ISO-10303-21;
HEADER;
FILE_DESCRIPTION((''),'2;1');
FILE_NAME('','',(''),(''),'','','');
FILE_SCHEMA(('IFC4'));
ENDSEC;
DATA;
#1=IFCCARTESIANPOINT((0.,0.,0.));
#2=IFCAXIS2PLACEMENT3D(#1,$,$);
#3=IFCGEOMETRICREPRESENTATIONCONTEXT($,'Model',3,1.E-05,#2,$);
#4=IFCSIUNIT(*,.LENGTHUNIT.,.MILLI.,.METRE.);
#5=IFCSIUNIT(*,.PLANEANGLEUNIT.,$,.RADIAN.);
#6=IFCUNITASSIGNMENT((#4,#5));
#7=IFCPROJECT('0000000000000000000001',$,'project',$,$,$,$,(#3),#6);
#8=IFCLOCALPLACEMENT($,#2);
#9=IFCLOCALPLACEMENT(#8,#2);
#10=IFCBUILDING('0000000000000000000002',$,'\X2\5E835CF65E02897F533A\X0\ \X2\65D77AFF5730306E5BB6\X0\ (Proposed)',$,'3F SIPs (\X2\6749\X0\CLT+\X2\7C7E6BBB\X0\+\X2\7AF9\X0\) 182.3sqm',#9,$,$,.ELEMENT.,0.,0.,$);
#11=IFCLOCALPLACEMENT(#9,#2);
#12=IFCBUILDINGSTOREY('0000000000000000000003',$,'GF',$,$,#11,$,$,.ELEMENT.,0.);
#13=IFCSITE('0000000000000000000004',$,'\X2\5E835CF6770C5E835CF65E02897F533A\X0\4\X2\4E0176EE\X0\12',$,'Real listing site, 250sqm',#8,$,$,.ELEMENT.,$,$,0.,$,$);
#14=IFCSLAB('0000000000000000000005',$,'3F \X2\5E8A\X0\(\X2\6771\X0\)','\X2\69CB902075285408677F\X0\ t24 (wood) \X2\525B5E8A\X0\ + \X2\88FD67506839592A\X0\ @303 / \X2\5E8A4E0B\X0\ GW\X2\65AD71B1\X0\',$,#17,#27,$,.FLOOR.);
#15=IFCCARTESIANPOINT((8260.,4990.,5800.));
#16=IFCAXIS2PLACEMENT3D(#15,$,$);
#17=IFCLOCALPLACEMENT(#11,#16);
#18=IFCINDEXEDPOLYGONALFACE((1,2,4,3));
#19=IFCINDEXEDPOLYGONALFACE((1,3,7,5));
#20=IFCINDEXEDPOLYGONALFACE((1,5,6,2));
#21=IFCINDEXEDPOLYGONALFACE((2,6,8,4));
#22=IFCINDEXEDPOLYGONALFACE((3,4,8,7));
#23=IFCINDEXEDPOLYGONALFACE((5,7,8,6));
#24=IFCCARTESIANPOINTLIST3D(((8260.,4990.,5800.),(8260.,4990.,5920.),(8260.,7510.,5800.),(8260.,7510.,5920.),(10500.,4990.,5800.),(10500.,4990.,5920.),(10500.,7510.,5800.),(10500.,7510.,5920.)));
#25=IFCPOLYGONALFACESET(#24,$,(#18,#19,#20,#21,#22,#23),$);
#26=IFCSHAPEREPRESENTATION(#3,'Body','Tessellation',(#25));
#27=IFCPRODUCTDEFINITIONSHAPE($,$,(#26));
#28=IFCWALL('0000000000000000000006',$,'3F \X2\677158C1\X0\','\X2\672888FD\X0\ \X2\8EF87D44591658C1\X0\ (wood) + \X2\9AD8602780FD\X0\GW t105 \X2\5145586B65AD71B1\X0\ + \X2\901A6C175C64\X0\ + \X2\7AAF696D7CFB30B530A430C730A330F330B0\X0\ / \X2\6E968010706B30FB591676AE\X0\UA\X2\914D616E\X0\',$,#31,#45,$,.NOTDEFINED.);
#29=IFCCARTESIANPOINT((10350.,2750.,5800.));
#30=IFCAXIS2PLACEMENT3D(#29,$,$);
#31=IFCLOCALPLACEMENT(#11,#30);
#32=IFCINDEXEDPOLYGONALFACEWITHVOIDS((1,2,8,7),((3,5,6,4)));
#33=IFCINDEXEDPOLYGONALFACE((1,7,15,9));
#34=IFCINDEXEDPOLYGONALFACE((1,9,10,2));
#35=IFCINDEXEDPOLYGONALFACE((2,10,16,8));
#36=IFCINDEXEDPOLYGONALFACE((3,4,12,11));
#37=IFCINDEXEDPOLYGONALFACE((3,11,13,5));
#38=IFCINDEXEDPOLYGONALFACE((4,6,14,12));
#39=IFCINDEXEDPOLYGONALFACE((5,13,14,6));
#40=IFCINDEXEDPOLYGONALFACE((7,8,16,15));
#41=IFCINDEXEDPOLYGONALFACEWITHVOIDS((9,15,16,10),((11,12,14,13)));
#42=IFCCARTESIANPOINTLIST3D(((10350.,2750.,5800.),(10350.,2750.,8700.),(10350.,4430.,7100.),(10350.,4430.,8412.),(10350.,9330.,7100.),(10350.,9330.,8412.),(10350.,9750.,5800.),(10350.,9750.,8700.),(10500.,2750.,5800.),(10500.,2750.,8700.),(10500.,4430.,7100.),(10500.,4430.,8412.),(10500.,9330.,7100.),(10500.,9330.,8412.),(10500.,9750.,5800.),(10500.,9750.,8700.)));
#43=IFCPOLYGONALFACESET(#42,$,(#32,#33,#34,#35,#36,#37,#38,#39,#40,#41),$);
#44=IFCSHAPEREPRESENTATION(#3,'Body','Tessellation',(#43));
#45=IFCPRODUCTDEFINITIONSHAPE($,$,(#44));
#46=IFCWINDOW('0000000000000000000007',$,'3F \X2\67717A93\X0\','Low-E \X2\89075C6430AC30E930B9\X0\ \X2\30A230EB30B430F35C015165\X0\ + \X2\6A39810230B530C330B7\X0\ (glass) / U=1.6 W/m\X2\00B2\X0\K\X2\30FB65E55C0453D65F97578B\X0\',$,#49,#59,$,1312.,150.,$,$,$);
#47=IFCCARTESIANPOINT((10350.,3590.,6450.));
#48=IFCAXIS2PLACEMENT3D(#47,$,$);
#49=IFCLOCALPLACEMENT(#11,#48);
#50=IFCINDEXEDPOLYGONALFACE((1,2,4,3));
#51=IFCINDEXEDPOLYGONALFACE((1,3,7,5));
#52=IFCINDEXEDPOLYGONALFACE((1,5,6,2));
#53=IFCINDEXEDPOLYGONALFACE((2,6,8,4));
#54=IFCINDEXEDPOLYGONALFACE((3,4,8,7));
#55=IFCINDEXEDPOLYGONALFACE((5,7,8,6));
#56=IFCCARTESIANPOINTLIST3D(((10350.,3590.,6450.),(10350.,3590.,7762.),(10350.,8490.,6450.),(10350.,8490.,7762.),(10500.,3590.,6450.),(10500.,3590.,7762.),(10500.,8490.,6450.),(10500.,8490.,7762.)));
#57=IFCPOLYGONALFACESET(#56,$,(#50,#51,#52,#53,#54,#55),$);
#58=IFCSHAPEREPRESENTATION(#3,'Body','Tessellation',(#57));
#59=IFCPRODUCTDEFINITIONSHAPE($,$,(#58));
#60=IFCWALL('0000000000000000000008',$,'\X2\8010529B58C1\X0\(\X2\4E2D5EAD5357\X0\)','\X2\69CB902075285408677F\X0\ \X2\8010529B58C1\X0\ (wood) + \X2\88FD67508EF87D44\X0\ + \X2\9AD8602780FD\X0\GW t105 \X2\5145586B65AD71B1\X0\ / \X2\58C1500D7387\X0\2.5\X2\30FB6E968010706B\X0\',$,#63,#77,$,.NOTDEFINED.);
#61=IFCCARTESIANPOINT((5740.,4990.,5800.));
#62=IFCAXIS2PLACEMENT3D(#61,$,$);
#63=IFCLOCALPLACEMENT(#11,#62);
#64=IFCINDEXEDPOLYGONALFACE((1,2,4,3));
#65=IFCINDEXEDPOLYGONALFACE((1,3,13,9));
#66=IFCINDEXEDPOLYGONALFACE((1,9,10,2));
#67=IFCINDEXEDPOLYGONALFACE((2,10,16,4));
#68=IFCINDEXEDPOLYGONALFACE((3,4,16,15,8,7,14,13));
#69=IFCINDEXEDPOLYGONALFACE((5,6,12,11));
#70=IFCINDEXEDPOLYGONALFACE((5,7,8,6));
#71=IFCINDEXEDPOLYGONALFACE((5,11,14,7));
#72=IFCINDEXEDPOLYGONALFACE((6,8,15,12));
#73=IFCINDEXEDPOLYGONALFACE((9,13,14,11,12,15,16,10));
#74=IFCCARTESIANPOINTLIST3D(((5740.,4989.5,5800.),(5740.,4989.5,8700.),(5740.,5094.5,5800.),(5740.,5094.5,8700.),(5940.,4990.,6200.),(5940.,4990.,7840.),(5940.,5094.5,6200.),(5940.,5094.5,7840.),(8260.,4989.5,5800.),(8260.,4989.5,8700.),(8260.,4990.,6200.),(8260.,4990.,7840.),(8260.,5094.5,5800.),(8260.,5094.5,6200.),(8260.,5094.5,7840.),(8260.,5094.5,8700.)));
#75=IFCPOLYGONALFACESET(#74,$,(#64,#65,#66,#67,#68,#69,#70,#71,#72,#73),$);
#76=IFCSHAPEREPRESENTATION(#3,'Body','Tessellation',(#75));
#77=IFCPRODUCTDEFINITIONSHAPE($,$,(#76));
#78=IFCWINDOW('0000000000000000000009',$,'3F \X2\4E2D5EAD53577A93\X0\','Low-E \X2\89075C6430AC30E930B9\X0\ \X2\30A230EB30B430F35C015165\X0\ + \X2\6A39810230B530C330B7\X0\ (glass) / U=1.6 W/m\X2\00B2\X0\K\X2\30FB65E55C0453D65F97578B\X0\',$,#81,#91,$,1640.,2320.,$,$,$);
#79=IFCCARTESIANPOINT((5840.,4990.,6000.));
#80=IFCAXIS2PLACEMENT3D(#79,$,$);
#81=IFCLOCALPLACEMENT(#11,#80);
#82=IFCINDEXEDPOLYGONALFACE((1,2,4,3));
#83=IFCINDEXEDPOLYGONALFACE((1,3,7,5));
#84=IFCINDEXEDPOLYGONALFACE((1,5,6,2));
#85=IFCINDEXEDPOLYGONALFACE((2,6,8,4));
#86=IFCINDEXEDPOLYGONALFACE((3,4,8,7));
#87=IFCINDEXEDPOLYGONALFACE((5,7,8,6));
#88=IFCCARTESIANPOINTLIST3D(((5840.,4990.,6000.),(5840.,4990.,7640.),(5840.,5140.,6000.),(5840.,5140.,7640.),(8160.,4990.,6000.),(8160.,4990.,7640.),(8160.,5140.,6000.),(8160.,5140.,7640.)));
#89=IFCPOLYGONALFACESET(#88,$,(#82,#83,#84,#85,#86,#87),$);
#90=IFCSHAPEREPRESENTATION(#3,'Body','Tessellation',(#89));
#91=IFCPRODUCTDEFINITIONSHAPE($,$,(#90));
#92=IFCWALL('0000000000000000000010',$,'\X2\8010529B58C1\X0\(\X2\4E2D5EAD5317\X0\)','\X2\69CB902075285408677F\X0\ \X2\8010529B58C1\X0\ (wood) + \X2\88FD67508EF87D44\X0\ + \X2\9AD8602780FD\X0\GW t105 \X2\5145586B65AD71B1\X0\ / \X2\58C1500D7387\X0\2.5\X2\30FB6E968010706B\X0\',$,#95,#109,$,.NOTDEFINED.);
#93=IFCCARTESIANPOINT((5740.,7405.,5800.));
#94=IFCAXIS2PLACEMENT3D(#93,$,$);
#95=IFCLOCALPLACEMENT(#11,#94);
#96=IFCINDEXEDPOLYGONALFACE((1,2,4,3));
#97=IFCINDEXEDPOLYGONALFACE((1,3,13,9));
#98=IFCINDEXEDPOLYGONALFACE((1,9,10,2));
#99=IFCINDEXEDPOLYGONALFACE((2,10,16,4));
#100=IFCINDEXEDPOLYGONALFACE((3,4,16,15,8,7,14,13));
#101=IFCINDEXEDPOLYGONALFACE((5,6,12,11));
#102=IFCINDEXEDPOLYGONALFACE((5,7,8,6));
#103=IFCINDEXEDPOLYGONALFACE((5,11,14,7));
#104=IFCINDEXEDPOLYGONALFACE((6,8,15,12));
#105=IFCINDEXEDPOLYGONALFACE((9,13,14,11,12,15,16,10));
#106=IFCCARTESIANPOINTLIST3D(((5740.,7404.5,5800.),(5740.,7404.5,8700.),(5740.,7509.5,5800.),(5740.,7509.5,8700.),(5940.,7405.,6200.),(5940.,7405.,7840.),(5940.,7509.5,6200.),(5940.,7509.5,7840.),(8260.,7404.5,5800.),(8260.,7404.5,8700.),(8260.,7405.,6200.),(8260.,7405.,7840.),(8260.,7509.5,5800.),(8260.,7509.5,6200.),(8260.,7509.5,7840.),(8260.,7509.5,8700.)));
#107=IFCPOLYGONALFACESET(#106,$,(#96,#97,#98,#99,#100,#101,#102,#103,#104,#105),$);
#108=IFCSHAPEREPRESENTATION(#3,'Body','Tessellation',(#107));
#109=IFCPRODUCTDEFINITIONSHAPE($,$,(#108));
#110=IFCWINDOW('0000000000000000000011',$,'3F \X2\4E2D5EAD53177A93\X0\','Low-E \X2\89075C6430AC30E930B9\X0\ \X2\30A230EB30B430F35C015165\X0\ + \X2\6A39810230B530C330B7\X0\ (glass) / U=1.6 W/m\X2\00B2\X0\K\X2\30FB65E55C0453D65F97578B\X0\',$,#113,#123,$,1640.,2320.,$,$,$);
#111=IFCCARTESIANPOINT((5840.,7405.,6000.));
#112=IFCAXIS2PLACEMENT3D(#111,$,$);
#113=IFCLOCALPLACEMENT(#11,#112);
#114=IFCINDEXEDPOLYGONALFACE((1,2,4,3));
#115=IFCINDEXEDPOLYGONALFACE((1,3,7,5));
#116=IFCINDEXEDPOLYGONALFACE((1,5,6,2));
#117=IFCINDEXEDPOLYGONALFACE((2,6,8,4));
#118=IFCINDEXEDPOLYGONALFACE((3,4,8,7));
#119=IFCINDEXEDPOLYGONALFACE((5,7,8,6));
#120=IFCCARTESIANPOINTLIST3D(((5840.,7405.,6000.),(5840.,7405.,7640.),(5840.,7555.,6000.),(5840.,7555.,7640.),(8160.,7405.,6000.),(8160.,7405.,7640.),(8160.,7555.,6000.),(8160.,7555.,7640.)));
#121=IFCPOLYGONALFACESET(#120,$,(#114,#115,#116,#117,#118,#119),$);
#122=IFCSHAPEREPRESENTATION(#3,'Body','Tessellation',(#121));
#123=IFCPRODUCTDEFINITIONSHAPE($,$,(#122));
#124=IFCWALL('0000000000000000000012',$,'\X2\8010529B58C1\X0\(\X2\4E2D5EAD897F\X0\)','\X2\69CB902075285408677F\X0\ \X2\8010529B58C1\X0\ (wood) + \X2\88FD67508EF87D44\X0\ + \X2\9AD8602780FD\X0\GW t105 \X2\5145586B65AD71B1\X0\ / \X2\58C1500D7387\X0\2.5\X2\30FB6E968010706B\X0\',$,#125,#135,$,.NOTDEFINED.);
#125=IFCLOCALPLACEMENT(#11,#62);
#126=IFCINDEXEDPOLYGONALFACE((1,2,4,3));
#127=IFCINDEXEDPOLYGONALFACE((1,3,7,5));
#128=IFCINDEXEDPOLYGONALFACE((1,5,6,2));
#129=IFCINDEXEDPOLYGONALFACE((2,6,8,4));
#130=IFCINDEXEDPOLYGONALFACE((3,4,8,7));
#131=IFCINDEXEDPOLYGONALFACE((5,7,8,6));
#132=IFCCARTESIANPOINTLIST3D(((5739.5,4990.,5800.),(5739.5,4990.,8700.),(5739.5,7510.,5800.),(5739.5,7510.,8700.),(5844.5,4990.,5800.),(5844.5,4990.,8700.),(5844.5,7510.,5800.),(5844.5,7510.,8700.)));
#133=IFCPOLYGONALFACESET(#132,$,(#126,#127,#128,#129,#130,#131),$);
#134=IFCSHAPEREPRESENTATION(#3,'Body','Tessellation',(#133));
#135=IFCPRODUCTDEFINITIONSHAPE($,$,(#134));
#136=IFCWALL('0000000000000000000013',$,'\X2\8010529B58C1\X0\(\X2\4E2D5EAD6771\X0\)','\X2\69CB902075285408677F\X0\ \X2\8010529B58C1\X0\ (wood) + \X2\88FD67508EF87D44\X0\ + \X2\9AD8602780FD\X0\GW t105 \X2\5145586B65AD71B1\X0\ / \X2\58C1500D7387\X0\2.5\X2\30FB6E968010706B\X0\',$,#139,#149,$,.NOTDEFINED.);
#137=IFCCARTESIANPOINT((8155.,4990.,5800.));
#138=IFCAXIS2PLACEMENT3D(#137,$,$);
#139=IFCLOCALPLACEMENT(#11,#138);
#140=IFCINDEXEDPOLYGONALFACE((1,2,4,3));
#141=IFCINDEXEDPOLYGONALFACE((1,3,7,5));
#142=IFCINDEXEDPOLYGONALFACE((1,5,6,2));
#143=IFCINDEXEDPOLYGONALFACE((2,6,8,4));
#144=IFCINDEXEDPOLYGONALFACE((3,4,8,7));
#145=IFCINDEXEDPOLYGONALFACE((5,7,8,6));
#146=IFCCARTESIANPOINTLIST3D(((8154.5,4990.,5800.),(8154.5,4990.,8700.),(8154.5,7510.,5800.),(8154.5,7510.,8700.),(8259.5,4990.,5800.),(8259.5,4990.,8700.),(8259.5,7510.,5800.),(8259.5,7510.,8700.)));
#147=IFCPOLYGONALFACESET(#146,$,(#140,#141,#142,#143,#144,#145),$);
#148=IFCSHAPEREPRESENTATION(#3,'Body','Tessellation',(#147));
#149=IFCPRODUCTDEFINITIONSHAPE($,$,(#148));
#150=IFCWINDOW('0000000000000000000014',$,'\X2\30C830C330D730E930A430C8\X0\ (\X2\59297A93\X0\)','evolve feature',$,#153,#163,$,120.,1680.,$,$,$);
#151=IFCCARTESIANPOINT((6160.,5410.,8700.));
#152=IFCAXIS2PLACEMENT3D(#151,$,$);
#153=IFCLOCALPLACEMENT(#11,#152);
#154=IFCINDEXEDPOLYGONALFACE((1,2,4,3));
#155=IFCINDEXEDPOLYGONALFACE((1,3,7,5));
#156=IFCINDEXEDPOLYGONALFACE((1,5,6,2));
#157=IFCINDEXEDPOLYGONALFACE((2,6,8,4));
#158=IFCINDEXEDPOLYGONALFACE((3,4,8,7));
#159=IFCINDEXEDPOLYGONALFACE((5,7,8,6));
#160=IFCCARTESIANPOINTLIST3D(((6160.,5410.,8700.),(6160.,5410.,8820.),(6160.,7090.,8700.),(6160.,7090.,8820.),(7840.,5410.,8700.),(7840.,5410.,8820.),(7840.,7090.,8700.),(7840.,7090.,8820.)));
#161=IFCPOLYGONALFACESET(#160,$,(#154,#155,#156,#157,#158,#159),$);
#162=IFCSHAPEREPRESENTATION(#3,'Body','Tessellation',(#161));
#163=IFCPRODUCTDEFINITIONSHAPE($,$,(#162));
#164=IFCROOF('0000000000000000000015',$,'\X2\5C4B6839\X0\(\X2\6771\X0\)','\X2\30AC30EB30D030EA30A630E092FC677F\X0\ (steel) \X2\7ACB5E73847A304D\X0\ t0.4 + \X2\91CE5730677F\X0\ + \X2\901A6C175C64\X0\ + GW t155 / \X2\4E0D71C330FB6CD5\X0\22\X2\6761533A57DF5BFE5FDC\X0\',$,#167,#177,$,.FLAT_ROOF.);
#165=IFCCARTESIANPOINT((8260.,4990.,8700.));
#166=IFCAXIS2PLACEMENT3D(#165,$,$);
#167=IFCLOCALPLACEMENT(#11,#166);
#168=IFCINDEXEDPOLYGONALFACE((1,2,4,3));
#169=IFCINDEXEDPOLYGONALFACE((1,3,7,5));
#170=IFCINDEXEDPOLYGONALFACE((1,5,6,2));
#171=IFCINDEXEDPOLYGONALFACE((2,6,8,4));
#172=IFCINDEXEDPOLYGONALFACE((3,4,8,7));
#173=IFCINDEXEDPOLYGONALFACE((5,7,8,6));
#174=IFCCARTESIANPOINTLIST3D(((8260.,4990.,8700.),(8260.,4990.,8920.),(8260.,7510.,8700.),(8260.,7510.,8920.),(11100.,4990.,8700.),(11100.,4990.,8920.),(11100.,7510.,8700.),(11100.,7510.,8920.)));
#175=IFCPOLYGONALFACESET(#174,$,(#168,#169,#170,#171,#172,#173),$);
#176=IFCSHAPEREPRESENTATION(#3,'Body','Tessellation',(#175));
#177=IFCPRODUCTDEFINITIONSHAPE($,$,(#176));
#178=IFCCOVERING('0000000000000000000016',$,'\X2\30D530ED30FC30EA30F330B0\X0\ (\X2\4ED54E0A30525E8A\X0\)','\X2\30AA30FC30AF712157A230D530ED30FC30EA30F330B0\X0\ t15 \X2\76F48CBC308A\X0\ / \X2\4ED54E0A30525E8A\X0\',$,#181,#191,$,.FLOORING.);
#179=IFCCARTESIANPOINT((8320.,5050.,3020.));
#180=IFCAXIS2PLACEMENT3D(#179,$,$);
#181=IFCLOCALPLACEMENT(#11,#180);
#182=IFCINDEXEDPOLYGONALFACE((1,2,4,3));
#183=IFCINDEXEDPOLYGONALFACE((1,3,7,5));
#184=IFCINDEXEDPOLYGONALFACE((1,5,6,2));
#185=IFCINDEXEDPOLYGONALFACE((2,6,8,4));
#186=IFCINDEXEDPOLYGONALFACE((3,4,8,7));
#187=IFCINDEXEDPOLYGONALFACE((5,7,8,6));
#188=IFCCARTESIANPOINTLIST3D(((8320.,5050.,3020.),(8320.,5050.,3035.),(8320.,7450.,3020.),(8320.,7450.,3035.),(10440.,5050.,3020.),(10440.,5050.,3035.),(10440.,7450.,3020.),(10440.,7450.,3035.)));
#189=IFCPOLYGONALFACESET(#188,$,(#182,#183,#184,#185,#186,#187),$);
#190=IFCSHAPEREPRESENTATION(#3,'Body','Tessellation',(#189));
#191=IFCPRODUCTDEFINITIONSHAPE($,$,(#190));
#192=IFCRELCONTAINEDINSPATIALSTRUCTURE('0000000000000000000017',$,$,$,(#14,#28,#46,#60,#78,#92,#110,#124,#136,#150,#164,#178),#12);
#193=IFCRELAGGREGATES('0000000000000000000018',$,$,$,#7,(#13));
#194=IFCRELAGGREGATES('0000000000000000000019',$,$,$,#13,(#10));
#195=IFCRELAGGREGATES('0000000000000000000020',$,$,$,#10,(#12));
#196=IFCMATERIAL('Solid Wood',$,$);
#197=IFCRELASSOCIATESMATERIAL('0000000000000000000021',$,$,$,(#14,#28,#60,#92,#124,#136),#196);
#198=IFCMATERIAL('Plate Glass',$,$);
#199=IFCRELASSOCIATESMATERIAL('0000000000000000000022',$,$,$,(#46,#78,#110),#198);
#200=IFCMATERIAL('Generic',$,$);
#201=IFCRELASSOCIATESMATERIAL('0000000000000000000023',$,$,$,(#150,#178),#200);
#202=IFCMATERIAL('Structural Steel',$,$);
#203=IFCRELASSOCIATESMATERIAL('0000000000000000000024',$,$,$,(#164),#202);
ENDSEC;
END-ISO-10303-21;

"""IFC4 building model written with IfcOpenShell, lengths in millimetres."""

from ifc_helpers import new_model, si_unit, frame, frame_2d, origin, place, context, project, spatial, rectangle, extrude, material, element, fill, save


model = new_model("IFC4")

# Units and contexts
model_context = context("Model", 3, precision=1e-05, world=origin())
ifc_project = project(units=[si_unit("LENGTHUNIT", "METRE", prefix="MILLI"), si_unit("PLANEANGLEUNIT", "RADIAN")], contexts=[model_context])

# Site, building, storey
site_placement = place(None, origin())
site = spatial("IfcSite", under=ifc_project, at=site_placement, Name="広島県広島市西区4丁目12", ObjectType="Real listing site, 250sqm", CompositionType="ELEMENT", RefElevation=0.0)
building_placement = place(site_placement, origin())
building = spatial("IfcBuilding", under=site, at=building_placement, Name="広島市西区 旗竿地の家 (Proposed)", ObjectType="3F SIPs (杉CLT+籾殻+竹) 182.3sqm", CompositionType="ELEMENT", ElevationOfRefHeight=0.0, ElevationOfTerrain=0.0)
storey_placement = place(building_placement, origin())
storey = spatial("IfcBuildingStorey", under=building, at=storey_placement, Name="GF", CompositionType="ELEMENT", Elevation=0.0)

# Slab
ifc_material_1 = material(Name="Solid Wood")
slab_placement = place(storey_placement, frame((8260.0, 4990.0, 5800.0)))
element("IfcSlab", 1, at=slab_placement, inside=storey, material=ifc_material_1, Name="3F 床(東)", Description="構造用合板 t24 (wood) 剛床 + 製材根太 @303 / 床下 GW断熱", PredefinedType="FLOOR", context=model_context, shape_type="SweptSolid", body=[
    extrude(rectangle(XDim=2240.0, YDim=2520.0, at=frame_2d((1120.0, 1260.0))), frame((8260.0, 4990.0, 5800.0)), (0.0, 0.0, 1.0), 120.0),
])

# Walls, openings, windows
wall_1_placement = place(storey_placement, frame((10350.0, 2750.0, 5800.0)))
wall_1 = element("IfcWall", 2, at=wall_1_placement, inside=storey, material=ifc_material_1, Name="3F 東壁", Description="木製 軸組外壁 (wood) + 高性能GW t105 充填断熱 + 通気層 + 窯業系サイディング / 準耐火・外皮UA配慮", PredefinedType="NOTDEFINED", context=model_context, shape_type="SweptSolid", body=[
    extrude(rectangle(XDim=150.0, YDim=7000.0, at=frame_2d((75.0, 3500.0))), frame((10350.0, 2750.0, 5800.0)), (0.0, 0.0, 1.0), 2900.0),
])
opening_1_placement = place(storey_placement, frame((10350.0, 3590.0, 6450.0)))
opening_1 = element("IfcOpeningElement", 3, at=opening_1_placement, cuts=wall_1, PredefinedType="NOTDEFINED", context=model_context, shape_type="SweptSolid", body=[
    extrude(rectangle(XDim=150.0, YDim=4900.0, at=frame_2d((75.0, 2450.0))), frame((10350.0, 3590.0, 6450.0)), (0.0, 0.0, 1.0), 1312.0),
])
ifc_material_2 = material(Name="Plate Glass")
window_1_placement = place(storey_placement, frame((10350.0, 3590.0, 6450.0)))
window_1 = element("IfcWindow", 4, at=window_1_placement, inside=storey, material=ifc_material_2, Name="3F 東窓", Description="Low-E 複層ガラス アルゴン封入 + 樹脂サッシ (glass) / U=1.6 W/m²K・日射取得型", OverallHeight=1312.0, OverallWidth=150.0, context=model_context, shape_type="SweptSolid", body=[
    extrude(rectangle(XDim=150.0, YDim=4900.0, at=frame_2d((75.0, 2450.0))), frame((10350.0, 3590.0, 6450.0)), (0.0, 0.0, 1.0), 1312.0),
])
fill(opening_1, window_1)
wall_2_placement = place(storey_placement, frame((5740.0, 4990.0, 5800.0)))
wall_2 = element("IfcWall", 5, at=wall_2_placement, inside=storey, material=ifc_material_1, Name="耐力壁(中庭南)", Description="構造用合板 耐力壁 (wood) + 製材軸組 + 高性能GW t105 充填断熱 / 壁倍率2.5・準耐火", PredefinedType="NOTDEFINED", context=model_context, shape_type="SweptSolid", body=[
    extrude(rectangle(XDim=2520.0, YDim=105.0, at=frame_2d((1260.0, 52.0))), frame((5740.0, 4990.0, 5800.0)), (0.0, 0.0, 1.0), 2900.0),
])
opening_2_placement = place(storey_placement, frame((5840.0, 4990.0, 6000.0)))
opening_2 = element("IfcOpeningElement", 6, at=opening_2_placement, cuts=wall_2, PredefinedType="NOTDEFINED", context=model_context, shape_type="SweptSolid", body=[
    extrude(rectangle(XDim=2320.0, YDim=150.0, at=frame_2d((1160.0, 75.0))), frame((5840.0, 4990.0, 6000.0)), (0.0, 0.0, 1.0), 1640.0),
])
window_2_placement = place(storey_placement, frame((5840.0, 4990.0, 6000.0)))
window_2 = element("IfcWindow", 7, at=window_2_placement, inside=storey, material=ifc_material_2, Name="3F 中庭南窓", Description="Low-E 複層ガラス アルゴン封入 + 樹脂サッシ (glass) / U=1.6 W/m²K・日射取得型", OverallHeight=1640.0, OverallWidth=2320.0, context=model_context, shape_type="SweptSolid", body=[
    extrude(rectangle(XDim=2320.0, YDim=150.0, at=frame_2d((1160.0, 75.0))), frame((5840.0, 4990.0, 6000.0)), (0.0, 0.0, 1.0), 1640.0),
])
fill(opening_2, window_2)
wall_3_placement = place(storey_placement, frame((5740.0, 7405.0, 5800.0)))
wall_3 = element("IfcWall", 8, at=wall_3_placement, inside=storey, material=ifc_material_1, Name="耐力壁(中庭北)", Description="構造用合板 耐力壁 (wood) + 製材軸組 + 高性能GW t105 充填断熱 / 壁倍率2.5・準耐火", PredefinedType="NOTDEFINED", context=model_context, shape_type="SweptSolid", body=[
    extrude(rectangle(XDim=2520.0, YDim=105.0, at=frame_2d((1260.0, 52.0))), frame((5740.0, 7405.0, 5800.0)), (0.0, 0.0, 1.0), 2900.0),
])
opening_3_placement = place(storey_placement, frame((5840.0, 7405.0, 6000.0)))
opening_3 = element("IfcOpeningElement", 9, at=opening_3_placement, cuts=wall_3, PredefinedType="NOTDEFINED", context=model_context, shape_type="SweptSolid", body=[
    extrude(rectangle(XDim=2320.0, YDim=150.0, at=frame_2d((1160.0, 75.0))), frame((5840.0, 7405.0, 6000.0)), (0.0, 0.0, 1.0), 1640.0),
])
window_3_placement = place(storey_placement, frame((5840.0, 7405.0, 6000.0)))
window_3 = element("IfcWindow", 10, at=window_3_placement, inside=storey, material=ifc_material_2, Name="3F 中庭北窓", Description="Low-E 複層ガラス アルゴン封入 + 樹脂サッシ (glass) / U=1.6 W/m²K・日射取得型", OverallHeight=1640.0, OverallWidth=2320.0, context=model_context, shape_type="SweptSolid", body=[
    extrude(rectangle(XDim=2320.0, YDim=150.0, at=frame_2d((1160.0, 75.0))), frame((5840.0, 7405.0, 6000.0)), (0.0, 0.0, 1.0), 1640.0),
])
fill(opening_3, window_3)

# Walls
wall_4_placement = place(storey_placement, frame((5740.0, 4990.0, 5800.0)))
element("IfcWall", 11, at=wall_4_placement, inside=storey, material=ifc_material_1, Name="耐力壁(中庭西)", Description="構造用合板 耐力壁 (wood) + 製材軸組 + 高性能GW t105 充填断熱 / 壁倍率2.5・準耐火", PredefinedType="NOTDEFINED", context=model_context, shape_type="SweptSolid", body=[
    extrude(rectangle(XDim=105.0, YDim=2520.0, at=frame_2d((52.0, 1260.0))), frame((5740.0, 4990.0, 5800.0)), (0.0, 0.0, 1.0), 2900.0),
])
wall_5_placement = place(storey_placement, frame((8155.0, 4990.0, 5800.0)))
element("IfcWall", 12, at=wall_5_placement, inside=storey, material=ifc_material_1, Name="耐力壁(中庭東)", Description="構造用合板 耐力壁 (wood) + 製材軸組 + 高性能GW t105 充填断熱 / 壁倍率2.5・準耐火", PredefinedType="NOTDEFINED", context=model_context, shape_type="SweptSolid", body=[
    extrude(rectangle(XDim=105.0, YDim=2520.0, at=frame_2d((52.0, 1260.0))), frame((8155.0, 4990.0, 5800.0)), (0.0, 0.0, 1.0), 2900.0),
])

# Window
ifc_material_3 = material(Name="Generic")
window_4_placement = place(storey_placement, frame((6160.0, 5410.0, 8700.0)))
element("IfcWindow", 13, at=window_4_placement, inside=storey, material=ifc_material_3, Name="トップライト (天窓)", Description="evolve feature", OverallHeight=120.0, OverallWidth=1680.0, context=model_context, shape_type="SweptSolid", body=[
    extrude(rectangle(XDim=1680.0, YDim=1680.0, at=frame_2d((840.0, 840.0))), frame((6160.0, 5410.0, 8700.0)), (0.0, 0.0, 1.0), 120.0),
])

# Roof
ifc_material_4 = material(Name="Structural Steel")
for number, where, name in (
    (14, (8260.0, 4990.0, 8700.0), "屋根(東)"),
):
    element("IfcRoof", number, at=place(storey_placement, frame(where)), inside=storey, material=ifc_material_4, Name=name, Description="ガルバリウム鋼板 (steel) 立平葺き t0.4 + 野地板 + 通気層 + GW t155 / 不燃・法22条区域対応", PredefinedType="FLAT_ROOF", context=model_context, shape_type="SweptSolid", body=[
        extrude(rectangle(XDim=2840.0, YDim=2520.0, at=frame_2d((1420.0, 1260.0))), frame((8260.0, 4990.0, 8700.0)), (0.0, 0.0, 1.0), 220.0),
    ])

# Covering
covering_1_placement = place(storey_placement, frame((8320.0, 5050.0, 3020.0)))
element("IfcCovering", 15, at=covering_1_placement, inside=storey, material=ifc_material_3, Name="フローリング (仕上げ床)", Description="オーク無垢フローリング t15 直貼り / 仕上げ床", PredefinedType="FLOORING", context=model_context, shape_type="SweptSolid", body=[
    extrude(rectangle(XDim=2120.0, YDim=2400.0, at=frame_2d((1060.0, 1200.0))), frame((8320.0, 5050.0, 3020.0)), (0.0, 0.0, 1.0), 15.0),
])

save(model, "model.ifc")
